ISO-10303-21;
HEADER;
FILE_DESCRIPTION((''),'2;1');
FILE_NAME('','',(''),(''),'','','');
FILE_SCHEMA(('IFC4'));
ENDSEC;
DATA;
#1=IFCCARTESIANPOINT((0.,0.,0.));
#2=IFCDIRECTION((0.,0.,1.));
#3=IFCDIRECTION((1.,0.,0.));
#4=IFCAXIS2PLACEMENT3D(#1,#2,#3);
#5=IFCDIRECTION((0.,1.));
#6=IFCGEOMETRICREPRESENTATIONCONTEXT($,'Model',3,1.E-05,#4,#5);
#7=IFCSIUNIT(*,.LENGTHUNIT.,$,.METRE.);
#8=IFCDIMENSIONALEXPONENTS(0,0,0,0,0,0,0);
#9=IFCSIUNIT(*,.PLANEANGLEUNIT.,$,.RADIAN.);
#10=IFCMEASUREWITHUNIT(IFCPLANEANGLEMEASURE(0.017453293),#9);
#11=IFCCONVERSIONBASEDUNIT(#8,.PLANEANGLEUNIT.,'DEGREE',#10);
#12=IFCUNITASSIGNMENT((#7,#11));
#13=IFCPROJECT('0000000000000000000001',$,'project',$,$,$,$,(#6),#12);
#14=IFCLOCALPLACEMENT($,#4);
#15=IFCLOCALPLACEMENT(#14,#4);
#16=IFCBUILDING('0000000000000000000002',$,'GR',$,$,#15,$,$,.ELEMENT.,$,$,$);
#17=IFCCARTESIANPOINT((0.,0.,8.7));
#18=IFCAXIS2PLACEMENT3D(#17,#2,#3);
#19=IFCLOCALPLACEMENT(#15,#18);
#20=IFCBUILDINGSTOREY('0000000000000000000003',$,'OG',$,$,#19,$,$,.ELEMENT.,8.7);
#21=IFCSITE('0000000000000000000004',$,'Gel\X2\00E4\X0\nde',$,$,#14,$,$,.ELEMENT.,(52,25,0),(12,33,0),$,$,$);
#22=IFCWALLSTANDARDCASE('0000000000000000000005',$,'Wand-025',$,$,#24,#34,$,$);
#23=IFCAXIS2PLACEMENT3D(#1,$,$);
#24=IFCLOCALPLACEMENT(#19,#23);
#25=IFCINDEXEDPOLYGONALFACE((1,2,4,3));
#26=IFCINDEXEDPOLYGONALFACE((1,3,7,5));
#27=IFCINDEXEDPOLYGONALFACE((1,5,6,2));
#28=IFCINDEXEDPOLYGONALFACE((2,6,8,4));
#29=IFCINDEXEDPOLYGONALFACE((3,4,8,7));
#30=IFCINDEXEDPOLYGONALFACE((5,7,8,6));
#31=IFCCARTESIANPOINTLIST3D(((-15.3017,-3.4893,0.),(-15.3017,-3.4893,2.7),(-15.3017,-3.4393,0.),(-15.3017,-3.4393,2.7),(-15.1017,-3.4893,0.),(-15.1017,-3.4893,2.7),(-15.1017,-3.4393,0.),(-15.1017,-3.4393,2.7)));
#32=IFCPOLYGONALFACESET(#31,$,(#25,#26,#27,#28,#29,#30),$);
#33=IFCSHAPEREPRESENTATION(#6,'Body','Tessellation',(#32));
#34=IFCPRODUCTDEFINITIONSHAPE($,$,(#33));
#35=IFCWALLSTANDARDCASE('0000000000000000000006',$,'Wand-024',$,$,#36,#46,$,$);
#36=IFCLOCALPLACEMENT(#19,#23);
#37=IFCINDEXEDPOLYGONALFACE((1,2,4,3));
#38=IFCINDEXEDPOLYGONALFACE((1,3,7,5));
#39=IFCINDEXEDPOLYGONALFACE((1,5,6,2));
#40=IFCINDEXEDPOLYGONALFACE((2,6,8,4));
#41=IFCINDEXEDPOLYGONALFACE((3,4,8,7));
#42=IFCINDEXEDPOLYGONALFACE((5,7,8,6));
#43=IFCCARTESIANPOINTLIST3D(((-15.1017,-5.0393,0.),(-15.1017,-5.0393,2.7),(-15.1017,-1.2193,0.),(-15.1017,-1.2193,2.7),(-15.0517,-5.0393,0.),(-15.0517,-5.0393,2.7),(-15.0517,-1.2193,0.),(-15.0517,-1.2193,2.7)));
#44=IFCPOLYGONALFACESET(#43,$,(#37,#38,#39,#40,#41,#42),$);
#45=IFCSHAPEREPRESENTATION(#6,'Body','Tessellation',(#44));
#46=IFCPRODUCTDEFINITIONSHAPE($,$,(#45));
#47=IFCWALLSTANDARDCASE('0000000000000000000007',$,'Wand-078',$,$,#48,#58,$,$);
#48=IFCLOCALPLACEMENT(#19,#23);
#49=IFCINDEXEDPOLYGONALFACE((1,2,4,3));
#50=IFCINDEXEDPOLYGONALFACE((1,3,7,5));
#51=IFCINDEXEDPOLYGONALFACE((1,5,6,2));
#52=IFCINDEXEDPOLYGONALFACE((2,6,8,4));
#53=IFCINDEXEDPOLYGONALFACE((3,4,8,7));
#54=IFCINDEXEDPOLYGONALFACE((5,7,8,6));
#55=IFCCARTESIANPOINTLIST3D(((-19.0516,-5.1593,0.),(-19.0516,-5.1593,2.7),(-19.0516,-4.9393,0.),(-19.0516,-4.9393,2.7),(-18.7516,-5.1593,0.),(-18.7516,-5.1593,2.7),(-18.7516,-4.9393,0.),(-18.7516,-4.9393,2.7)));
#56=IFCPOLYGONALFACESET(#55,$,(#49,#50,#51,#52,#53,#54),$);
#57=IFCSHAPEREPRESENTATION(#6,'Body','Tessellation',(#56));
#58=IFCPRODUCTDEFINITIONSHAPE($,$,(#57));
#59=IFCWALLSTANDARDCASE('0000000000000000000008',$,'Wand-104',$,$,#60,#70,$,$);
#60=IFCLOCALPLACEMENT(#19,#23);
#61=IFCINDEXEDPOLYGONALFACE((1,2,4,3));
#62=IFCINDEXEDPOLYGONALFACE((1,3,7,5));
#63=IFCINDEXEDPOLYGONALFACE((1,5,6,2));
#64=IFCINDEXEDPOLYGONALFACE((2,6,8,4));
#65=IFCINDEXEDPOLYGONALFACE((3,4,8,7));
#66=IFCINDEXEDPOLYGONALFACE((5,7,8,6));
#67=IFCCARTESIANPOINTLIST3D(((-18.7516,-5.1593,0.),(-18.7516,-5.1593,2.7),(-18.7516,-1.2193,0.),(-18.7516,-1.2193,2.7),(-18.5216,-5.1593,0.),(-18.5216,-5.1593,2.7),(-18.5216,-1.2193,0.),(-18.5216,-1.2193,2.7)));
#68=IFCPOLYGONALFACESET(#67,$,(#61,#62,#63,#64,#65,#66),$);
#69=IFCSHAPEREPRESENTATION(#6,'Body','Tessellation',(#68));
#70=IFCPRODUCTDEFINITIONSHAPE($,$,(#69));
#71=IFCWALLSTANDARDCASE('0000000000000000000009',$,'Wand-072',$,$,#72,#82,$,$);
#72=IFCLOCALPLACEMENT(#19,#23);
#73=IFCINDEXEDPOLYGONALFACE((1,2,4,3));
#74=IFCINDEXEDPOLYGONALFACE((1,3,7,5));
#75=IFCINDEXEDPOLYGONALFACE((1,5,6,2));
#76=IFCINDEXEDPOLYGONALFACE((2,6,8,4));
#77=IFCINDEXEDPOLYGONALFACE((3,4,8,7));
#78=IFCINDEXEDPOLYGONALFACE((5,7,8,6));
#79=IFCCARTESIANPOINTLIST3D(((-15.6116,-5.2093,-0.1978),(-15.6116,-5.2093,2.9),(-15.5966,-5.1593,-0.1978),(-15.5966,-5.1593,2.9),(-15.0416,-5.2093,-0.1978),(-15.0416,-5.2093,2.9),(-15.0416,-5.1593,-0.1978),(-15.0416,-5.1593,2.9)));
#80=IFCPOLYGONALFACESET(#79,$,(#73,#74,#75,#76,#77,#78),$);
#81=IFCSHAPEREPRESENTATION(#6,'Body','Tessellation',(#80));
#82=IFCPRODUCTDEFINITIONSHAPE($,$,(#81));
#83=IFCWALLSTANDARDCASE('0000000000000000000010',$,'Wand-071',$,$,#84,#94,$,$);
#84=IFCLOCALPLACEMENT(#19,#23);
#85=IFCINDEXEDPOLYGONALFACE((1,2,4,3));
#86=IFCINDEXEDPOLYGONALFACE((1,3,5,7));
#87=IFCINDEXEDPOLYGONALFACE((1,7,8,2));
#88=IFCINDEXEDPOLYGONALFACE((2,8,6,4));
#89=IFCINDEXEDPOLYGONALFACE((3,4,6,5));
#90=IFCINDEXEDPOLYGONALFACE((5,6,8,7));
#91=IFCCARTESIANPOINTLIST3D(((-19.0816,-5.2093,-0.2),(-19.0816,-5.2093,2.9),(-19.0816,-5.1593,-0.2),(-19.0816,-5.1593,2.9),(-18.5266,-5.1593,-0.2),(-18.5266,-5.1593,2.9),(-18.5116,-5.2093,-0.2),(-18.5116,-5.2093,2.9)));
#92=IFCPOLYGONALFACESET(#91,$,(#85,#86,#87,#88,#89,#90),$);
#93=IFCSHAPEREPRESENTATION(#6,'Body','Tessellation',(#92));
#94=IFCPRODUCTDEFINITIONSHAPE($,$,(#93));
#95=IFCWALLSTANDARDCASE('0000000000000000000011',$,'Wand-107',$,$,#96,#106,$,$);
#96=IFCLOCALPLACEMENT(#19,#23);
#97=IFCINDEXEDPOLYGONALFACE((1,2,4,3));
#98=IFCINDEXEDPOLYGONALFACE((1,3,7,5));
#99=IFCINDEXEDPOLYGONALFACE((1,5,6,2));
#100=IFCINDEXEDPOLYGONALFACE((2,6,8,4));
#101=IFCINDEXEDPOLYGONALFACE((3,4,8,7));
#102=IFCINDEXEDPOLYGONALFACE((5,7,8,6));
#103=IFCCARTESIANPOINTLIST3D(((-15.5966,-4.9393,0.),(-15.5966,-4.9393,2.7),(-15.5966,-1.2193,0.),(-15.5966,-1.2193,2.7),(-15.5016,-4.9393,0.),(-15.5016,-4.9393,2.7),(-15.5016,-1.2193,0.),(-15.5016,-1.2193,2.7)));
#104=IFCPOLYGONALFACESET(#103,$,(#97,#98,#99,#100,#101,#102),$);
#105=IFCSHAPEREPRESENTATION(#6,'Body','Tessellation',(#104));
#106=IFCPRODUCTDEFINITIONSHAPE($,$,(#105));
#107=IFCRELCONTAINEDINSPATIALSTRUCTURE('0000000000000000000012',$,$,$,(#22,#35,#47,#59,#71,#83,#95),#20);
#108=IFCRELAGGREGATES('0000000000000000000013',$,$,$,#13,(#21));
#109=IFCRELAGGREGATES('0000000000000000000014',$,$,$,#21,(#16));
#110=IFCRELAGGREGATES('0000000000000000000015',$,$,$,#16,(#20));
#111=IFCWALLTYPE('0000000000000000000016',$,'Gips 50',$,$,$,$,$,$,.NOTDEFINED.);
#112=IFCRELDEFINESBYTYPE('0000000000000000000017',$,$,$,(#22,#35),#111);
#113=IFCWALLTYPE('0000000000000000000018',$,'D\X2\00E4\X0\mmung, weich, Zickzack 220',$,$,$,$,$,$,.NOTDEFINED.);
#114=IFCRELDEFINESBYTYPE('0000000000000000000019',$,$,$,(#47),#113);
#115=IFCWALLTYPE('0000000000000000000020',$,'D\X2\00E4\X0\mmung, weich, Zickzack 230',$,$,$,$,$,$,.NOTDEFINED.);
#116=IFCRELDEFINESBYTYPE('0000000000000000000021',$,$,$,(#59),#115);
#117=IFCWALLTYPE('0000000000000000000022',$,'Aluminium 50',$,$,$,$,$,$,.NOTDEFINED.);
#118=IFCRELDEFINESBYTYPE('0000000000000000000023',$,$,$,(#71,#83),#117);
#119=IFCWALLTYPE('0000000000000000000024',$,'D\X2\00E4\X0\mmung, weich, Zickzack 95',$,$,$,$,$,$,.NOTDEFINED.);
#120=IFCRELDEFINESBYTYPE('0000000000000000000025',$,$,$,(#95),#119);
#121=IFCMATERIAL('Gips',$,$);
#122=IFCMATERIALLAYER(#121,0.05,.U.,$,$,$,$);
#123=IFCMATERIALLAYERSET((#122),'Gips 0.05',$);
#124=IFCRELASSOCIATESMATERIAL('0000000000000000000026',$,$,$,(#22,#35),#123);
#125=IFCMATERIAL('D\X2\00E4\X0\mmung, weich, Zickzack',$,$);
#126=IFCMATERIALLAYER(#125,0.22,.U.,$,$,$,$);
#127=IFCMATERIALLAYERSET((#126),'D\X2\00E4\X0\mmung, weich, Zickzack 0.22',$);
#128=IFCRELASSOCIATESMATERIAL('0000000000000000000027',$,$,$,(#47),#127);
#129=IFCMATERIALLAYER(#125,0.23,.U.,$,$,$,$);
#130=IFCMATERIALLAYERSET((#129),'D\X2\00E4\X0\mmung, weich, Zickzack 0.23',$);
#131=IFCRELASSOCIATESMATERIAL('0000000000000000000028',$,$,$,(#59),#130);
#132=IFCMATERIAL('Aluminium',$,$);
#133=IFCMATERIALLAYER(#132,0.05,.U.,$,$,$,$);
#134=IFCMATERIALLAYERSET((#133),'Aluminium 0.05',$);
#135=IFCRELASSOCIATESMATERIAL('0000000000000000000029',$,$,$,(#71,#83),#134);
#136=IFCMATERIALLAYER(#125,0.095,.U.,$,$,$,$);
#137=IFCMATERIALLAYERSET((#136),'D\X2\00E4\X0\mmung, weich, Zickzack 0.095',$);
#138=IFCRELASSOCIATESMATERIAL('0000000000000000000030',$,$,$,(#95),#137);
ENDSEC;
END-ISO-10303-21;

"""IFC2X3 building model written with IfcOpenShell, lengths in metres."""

from ifc_helpers import new_model, entity, si_unit, converted_unit, direction, frame, origin_with_axes, place, context, project, spatial, polyline, outline, extrude, material, layer, layer_set, layer_usage, type_object, element, save


model = new_model("IFC2X3")

# Units and contexts
model_context = context("Model", 3, precision=1e-05, world=origin_with_axes(), true_north=direction((0.0, 1.0)))
ifc_project = project(units=[si_unit("LENGTHUNIT", "METRE"), converted_unit("PLANEANGLEUNIT", "DEGREE", entity("IfcPlaneAngleMeasure", 0.017453293), si_unit("PLANEANGLEUNIT", "RADIAN"), dimensions=[0, 0, 0, 0, 0, 0, 0])], contexts=[model_context])

# Site, building, storey
site_placement = place(None, origin_with_axes())
site = spatial("IfcSite", under=ifc_project, at=site_placement, Name="Gelände", CompositionType="ELEMENT", RefLatitude=(52, 25, 0), RefLongitude=(12, 33, 0))
building_placement = place(site_placement, origin_with_axes())
building = spatial("IfcBuilding", under=site, at=building_placement, Name="GR", CompositionType="ELEMENT")
storey_placement = place(building_placement, frame((0.0, 0.0, 8.7), z_axis=(0.0, 0.0, 1.0), x_axis=(1.0, 0.0, 0.0)))
storey = spatial("IfcBuildingStorey", under=building, at=storey_placement, Name="OG", CompositionType="ELEMENT", Elevation=8.7)

# Shared definitions
ifc_material_1 = material(Name="Dämmung, weich, Zickzack")

# Walls
ifc_material_2 = material(Name="Gips")
ifc_layer_1 = layer(ifc_material_2, 0.05, ventilated="UNKNOWN")
ifc_layer_set_1 = layer_set([ifc_layer_1], Name="Gips 0.05")
ifc_layer_usage_1 = layer_usage(ifc_layer_set_1, "AXIS2", "NEGATIVE", 0.0)
wall_type_1 = type_object("IfcWallType", Name="Gips 50", PredefinedType="NOTDEFINED")
wall_1_placement = place(storey_placement, frame((-15.1017, -3.4893, 0.0), z_axis=(0.0, 0.0, 1.0), x_axis=(-1.0, 0.0, 0.0)))
element("IfcWallStandardCase", 1, at=wall_1_placement, inside=storey, type_object=wall_type_1, material=ifc_layer_usage_1, Name="Wand-025", context=model_context, shape_type="SweptSolid", body=[
    extrude(outline(polyline([(0.0, -0.05), (0.2, -0.05), (0.2, 0.0), (0.0, 0.0), (0.0, -0.05)])), origin_with_axes(), (0.0, 0.0, 1.0), 2.7),
])
ifc_layer_usage_2 = layer_usage(ifc_layer_set_1, "AXIS2", "NEGATIVE", 0.0)
wall_2_placement = place(storey_placement, frame((-15.1017, -5.0393, 0.0), z_axis=(0.0, 0.0, 1.0), x_axis=(0.0, 1.0, 0.0)))
element("IfcWallStandardCase", 2, at=wall_2_placement, inside=storey, type_object=wall_type_1, material=ifc_layer_usage_2, Name="Wand-024", context=model_context, shape_type="SweptSolid", body=[
    extrude(outline(polyline([(0.0, -0.05), (3.82, -0.05), (3.82, 0.0), (0.0, 0.0), (0.0, -0.05)])), origin_with_axes(), (0.0, 0.0, 1.0), 2.7),
])
ifc_layer_2 = layer(ifc_material_1, 0.22, ventilated="UNKNOWN")
ifc_layer_set_2 = layer_set([ifc_layer_2], Name="Dämmung, weich, Zickzack 0.22")
wall_type_2 = type_object("IfcWallType", Name="Dämmung, weich, Zickzack 220", PredefinedType="NOTDEFINED")
ifc_layer_usage_3 = layer_usage(ifc_layer_set_2, "AXIS2", "NEGATIVE", 0.0)
wall_3_placement = place(storey_placement, frame((-19.0516, -4.9393, 0.0), z_axis=(0.0, 0.0, 1.0), x_axis=(1.0, 0.0, 0.0)))
element("IfcWallStandardCase", 3, at=wall_3_placement, inside=storey, type_object=wall_type_2, material=ifc_layer_usage_3, Name="Wand-078", context=model_context, shape_type="SweptSolid", body=[
    extrude(outline(polyline([(0.0, -0.22), (0.3, -0.22), (0.3, 0.0), (0.0, 0.0), (0.0, -0.22)])), origin_with_axes(), (0.0, 0.0, 1.0), 2.7),
])
ifc_layer_3 = layer(ifc_material_1, 0.23, ventilated="UNKNOWN")
ifc_layer_set_3 = layer_set([ifc_layer_3], Name="Dämmung, weich, Zickzack 0.23")
ifc_layer_usage_4 = layer_usage(ifc_layer_set_3, "AXIS2", "NEGATIVE", 0.0)
wall_type_3 = type_object("IfcWallType", Name="Dämmung, weich, Zickzack 230", PredefinedType="NOTDEFINED")
wall_4_placement = place(storey_placement, frame((-18.7516, -5.1593, 0.0), z_axis=(0.0, 0.0, 1.0), x_axis=(0.0, 1.0, 0.0)))
element("IfcWallStandardCase", 4, at=wall_4_placement, inside=storey, type_object=wall_type_3, material=ifc_layer_usage_4, Name="Wand-104", context=model_context, shape_type="SweptSolid", body=[
    extrude(outline(polyline([(0.0, -0.23), (3.94, -0.23), (3.94, 0.0), (0.0, 0.0), (0.0, -0.23)])), origin_with_axes(), (0.0, 0.0, 1.0), 2.7),
])
ifc_material_3 = material(Name="Aluminium")
ifc_layer_4 = layer(ifc_material_3, 0.05, ventilated="UNKNOWN")
ifc_layer_set_4 = layer_set([ifc_layer_4], Name="Aluminium 0.05")
ifc_layer_usage_5 = layer_usage(ifc_layer_set_4, "AXIS2", "NEGATIVE", 0.0)
wall_type_4 = type_object("IfcWallType", Name="Aluminium 50", PredefinedType="NOTDEFINED")
wall_5_placement = place(storey_placement, frame((-15.6116, -5.1593, -0.1978), z_axis=(0.0, 0.0, 1.0), x_axis=(1.0, 0.0, 0.0)))
element("IfcWallStandardCase", 5, at=wall_5_placement, inside=storey, type_object=wall_type_4, material=ifc_layer_usage_5, Name="Wand-072", context=model_context, shape_type="SweptSolid", body=[
    extrude(outline(polyline([(0.0, -0.05), (0.57, -0.05), (0.57, 0.0), (0.015, 0.0), (0.0, -0.05)])), origin_with_axes(), (0.0, 0.0, 1.0), 3.0978),
])
ifc_layer_usage_6 = layer_usage(ifc_layer_set_4, "AXIS2", "NEGATIVE", 0.0)
wall_6_placement = place(storey_placement, frame((-19.0816, -5.1593, -0.2), z_axis=(0.0, 0.0, 1.0), x_axis=(1.0, 0.0, 0.0)))
element("IfcWallStandardCase", 6, at=wall_6_placement, inside=storey, type_object=wall_type_4, material=ifc_layer_usage_6, Name="Wand-071", context=model_context, shape_type="SweptSolid", body=[
    extrude(outline(polyline([(0.0, -0.05), (0.57, -0.05), (0.555, 0.0), (0.0, 0.0), (0.0, -0.05)])), origin_with_axes(), (0.0, 0.0, 1.0), 3.1),
])
ifc_layer_5 = layer(ifc_material_1, 0.095, ventilated="UNKNOWN")
ifc_layer_set_5 = layer_set([ifc_layer_5], Name="Dämmung, weich, Zickzack 0.095")
ifc_layer_usage_7 = layer_usage(ifc_layer_set_5, "AXIS2", "NEGATIVE", 0.0)
wall_type_5 = type_object("IfcWallType", Name="Dämmung, weich, Zickzack 95", PredefinedType="NOTDEFINED")
wall_7_placement = place(storey_placement, frame((-15.5966, -4.9393, 0.0), z_axis=(0.0, 0.0, 1.0), x_axis=(0.0, 1.0, 0.0)))
element("IfcWallStandardCase", 7, at=wall_7_placement, inside=storey, type_object=wall_type_5, material=ifc_layer_usage_7, Name="Wand-107", context=model_context, shape_type="SweptSolid", body=[
    extrude(outline(polyline([(0.0, -0.095), (3.72, -0.095), (3.72, 0.0), (0.0, 0.0), (0.0, -0.095)])), origin_with_axes(), (0.0, 0.0, 1.0), 2.7),
])

save(model, "model.ifc")
